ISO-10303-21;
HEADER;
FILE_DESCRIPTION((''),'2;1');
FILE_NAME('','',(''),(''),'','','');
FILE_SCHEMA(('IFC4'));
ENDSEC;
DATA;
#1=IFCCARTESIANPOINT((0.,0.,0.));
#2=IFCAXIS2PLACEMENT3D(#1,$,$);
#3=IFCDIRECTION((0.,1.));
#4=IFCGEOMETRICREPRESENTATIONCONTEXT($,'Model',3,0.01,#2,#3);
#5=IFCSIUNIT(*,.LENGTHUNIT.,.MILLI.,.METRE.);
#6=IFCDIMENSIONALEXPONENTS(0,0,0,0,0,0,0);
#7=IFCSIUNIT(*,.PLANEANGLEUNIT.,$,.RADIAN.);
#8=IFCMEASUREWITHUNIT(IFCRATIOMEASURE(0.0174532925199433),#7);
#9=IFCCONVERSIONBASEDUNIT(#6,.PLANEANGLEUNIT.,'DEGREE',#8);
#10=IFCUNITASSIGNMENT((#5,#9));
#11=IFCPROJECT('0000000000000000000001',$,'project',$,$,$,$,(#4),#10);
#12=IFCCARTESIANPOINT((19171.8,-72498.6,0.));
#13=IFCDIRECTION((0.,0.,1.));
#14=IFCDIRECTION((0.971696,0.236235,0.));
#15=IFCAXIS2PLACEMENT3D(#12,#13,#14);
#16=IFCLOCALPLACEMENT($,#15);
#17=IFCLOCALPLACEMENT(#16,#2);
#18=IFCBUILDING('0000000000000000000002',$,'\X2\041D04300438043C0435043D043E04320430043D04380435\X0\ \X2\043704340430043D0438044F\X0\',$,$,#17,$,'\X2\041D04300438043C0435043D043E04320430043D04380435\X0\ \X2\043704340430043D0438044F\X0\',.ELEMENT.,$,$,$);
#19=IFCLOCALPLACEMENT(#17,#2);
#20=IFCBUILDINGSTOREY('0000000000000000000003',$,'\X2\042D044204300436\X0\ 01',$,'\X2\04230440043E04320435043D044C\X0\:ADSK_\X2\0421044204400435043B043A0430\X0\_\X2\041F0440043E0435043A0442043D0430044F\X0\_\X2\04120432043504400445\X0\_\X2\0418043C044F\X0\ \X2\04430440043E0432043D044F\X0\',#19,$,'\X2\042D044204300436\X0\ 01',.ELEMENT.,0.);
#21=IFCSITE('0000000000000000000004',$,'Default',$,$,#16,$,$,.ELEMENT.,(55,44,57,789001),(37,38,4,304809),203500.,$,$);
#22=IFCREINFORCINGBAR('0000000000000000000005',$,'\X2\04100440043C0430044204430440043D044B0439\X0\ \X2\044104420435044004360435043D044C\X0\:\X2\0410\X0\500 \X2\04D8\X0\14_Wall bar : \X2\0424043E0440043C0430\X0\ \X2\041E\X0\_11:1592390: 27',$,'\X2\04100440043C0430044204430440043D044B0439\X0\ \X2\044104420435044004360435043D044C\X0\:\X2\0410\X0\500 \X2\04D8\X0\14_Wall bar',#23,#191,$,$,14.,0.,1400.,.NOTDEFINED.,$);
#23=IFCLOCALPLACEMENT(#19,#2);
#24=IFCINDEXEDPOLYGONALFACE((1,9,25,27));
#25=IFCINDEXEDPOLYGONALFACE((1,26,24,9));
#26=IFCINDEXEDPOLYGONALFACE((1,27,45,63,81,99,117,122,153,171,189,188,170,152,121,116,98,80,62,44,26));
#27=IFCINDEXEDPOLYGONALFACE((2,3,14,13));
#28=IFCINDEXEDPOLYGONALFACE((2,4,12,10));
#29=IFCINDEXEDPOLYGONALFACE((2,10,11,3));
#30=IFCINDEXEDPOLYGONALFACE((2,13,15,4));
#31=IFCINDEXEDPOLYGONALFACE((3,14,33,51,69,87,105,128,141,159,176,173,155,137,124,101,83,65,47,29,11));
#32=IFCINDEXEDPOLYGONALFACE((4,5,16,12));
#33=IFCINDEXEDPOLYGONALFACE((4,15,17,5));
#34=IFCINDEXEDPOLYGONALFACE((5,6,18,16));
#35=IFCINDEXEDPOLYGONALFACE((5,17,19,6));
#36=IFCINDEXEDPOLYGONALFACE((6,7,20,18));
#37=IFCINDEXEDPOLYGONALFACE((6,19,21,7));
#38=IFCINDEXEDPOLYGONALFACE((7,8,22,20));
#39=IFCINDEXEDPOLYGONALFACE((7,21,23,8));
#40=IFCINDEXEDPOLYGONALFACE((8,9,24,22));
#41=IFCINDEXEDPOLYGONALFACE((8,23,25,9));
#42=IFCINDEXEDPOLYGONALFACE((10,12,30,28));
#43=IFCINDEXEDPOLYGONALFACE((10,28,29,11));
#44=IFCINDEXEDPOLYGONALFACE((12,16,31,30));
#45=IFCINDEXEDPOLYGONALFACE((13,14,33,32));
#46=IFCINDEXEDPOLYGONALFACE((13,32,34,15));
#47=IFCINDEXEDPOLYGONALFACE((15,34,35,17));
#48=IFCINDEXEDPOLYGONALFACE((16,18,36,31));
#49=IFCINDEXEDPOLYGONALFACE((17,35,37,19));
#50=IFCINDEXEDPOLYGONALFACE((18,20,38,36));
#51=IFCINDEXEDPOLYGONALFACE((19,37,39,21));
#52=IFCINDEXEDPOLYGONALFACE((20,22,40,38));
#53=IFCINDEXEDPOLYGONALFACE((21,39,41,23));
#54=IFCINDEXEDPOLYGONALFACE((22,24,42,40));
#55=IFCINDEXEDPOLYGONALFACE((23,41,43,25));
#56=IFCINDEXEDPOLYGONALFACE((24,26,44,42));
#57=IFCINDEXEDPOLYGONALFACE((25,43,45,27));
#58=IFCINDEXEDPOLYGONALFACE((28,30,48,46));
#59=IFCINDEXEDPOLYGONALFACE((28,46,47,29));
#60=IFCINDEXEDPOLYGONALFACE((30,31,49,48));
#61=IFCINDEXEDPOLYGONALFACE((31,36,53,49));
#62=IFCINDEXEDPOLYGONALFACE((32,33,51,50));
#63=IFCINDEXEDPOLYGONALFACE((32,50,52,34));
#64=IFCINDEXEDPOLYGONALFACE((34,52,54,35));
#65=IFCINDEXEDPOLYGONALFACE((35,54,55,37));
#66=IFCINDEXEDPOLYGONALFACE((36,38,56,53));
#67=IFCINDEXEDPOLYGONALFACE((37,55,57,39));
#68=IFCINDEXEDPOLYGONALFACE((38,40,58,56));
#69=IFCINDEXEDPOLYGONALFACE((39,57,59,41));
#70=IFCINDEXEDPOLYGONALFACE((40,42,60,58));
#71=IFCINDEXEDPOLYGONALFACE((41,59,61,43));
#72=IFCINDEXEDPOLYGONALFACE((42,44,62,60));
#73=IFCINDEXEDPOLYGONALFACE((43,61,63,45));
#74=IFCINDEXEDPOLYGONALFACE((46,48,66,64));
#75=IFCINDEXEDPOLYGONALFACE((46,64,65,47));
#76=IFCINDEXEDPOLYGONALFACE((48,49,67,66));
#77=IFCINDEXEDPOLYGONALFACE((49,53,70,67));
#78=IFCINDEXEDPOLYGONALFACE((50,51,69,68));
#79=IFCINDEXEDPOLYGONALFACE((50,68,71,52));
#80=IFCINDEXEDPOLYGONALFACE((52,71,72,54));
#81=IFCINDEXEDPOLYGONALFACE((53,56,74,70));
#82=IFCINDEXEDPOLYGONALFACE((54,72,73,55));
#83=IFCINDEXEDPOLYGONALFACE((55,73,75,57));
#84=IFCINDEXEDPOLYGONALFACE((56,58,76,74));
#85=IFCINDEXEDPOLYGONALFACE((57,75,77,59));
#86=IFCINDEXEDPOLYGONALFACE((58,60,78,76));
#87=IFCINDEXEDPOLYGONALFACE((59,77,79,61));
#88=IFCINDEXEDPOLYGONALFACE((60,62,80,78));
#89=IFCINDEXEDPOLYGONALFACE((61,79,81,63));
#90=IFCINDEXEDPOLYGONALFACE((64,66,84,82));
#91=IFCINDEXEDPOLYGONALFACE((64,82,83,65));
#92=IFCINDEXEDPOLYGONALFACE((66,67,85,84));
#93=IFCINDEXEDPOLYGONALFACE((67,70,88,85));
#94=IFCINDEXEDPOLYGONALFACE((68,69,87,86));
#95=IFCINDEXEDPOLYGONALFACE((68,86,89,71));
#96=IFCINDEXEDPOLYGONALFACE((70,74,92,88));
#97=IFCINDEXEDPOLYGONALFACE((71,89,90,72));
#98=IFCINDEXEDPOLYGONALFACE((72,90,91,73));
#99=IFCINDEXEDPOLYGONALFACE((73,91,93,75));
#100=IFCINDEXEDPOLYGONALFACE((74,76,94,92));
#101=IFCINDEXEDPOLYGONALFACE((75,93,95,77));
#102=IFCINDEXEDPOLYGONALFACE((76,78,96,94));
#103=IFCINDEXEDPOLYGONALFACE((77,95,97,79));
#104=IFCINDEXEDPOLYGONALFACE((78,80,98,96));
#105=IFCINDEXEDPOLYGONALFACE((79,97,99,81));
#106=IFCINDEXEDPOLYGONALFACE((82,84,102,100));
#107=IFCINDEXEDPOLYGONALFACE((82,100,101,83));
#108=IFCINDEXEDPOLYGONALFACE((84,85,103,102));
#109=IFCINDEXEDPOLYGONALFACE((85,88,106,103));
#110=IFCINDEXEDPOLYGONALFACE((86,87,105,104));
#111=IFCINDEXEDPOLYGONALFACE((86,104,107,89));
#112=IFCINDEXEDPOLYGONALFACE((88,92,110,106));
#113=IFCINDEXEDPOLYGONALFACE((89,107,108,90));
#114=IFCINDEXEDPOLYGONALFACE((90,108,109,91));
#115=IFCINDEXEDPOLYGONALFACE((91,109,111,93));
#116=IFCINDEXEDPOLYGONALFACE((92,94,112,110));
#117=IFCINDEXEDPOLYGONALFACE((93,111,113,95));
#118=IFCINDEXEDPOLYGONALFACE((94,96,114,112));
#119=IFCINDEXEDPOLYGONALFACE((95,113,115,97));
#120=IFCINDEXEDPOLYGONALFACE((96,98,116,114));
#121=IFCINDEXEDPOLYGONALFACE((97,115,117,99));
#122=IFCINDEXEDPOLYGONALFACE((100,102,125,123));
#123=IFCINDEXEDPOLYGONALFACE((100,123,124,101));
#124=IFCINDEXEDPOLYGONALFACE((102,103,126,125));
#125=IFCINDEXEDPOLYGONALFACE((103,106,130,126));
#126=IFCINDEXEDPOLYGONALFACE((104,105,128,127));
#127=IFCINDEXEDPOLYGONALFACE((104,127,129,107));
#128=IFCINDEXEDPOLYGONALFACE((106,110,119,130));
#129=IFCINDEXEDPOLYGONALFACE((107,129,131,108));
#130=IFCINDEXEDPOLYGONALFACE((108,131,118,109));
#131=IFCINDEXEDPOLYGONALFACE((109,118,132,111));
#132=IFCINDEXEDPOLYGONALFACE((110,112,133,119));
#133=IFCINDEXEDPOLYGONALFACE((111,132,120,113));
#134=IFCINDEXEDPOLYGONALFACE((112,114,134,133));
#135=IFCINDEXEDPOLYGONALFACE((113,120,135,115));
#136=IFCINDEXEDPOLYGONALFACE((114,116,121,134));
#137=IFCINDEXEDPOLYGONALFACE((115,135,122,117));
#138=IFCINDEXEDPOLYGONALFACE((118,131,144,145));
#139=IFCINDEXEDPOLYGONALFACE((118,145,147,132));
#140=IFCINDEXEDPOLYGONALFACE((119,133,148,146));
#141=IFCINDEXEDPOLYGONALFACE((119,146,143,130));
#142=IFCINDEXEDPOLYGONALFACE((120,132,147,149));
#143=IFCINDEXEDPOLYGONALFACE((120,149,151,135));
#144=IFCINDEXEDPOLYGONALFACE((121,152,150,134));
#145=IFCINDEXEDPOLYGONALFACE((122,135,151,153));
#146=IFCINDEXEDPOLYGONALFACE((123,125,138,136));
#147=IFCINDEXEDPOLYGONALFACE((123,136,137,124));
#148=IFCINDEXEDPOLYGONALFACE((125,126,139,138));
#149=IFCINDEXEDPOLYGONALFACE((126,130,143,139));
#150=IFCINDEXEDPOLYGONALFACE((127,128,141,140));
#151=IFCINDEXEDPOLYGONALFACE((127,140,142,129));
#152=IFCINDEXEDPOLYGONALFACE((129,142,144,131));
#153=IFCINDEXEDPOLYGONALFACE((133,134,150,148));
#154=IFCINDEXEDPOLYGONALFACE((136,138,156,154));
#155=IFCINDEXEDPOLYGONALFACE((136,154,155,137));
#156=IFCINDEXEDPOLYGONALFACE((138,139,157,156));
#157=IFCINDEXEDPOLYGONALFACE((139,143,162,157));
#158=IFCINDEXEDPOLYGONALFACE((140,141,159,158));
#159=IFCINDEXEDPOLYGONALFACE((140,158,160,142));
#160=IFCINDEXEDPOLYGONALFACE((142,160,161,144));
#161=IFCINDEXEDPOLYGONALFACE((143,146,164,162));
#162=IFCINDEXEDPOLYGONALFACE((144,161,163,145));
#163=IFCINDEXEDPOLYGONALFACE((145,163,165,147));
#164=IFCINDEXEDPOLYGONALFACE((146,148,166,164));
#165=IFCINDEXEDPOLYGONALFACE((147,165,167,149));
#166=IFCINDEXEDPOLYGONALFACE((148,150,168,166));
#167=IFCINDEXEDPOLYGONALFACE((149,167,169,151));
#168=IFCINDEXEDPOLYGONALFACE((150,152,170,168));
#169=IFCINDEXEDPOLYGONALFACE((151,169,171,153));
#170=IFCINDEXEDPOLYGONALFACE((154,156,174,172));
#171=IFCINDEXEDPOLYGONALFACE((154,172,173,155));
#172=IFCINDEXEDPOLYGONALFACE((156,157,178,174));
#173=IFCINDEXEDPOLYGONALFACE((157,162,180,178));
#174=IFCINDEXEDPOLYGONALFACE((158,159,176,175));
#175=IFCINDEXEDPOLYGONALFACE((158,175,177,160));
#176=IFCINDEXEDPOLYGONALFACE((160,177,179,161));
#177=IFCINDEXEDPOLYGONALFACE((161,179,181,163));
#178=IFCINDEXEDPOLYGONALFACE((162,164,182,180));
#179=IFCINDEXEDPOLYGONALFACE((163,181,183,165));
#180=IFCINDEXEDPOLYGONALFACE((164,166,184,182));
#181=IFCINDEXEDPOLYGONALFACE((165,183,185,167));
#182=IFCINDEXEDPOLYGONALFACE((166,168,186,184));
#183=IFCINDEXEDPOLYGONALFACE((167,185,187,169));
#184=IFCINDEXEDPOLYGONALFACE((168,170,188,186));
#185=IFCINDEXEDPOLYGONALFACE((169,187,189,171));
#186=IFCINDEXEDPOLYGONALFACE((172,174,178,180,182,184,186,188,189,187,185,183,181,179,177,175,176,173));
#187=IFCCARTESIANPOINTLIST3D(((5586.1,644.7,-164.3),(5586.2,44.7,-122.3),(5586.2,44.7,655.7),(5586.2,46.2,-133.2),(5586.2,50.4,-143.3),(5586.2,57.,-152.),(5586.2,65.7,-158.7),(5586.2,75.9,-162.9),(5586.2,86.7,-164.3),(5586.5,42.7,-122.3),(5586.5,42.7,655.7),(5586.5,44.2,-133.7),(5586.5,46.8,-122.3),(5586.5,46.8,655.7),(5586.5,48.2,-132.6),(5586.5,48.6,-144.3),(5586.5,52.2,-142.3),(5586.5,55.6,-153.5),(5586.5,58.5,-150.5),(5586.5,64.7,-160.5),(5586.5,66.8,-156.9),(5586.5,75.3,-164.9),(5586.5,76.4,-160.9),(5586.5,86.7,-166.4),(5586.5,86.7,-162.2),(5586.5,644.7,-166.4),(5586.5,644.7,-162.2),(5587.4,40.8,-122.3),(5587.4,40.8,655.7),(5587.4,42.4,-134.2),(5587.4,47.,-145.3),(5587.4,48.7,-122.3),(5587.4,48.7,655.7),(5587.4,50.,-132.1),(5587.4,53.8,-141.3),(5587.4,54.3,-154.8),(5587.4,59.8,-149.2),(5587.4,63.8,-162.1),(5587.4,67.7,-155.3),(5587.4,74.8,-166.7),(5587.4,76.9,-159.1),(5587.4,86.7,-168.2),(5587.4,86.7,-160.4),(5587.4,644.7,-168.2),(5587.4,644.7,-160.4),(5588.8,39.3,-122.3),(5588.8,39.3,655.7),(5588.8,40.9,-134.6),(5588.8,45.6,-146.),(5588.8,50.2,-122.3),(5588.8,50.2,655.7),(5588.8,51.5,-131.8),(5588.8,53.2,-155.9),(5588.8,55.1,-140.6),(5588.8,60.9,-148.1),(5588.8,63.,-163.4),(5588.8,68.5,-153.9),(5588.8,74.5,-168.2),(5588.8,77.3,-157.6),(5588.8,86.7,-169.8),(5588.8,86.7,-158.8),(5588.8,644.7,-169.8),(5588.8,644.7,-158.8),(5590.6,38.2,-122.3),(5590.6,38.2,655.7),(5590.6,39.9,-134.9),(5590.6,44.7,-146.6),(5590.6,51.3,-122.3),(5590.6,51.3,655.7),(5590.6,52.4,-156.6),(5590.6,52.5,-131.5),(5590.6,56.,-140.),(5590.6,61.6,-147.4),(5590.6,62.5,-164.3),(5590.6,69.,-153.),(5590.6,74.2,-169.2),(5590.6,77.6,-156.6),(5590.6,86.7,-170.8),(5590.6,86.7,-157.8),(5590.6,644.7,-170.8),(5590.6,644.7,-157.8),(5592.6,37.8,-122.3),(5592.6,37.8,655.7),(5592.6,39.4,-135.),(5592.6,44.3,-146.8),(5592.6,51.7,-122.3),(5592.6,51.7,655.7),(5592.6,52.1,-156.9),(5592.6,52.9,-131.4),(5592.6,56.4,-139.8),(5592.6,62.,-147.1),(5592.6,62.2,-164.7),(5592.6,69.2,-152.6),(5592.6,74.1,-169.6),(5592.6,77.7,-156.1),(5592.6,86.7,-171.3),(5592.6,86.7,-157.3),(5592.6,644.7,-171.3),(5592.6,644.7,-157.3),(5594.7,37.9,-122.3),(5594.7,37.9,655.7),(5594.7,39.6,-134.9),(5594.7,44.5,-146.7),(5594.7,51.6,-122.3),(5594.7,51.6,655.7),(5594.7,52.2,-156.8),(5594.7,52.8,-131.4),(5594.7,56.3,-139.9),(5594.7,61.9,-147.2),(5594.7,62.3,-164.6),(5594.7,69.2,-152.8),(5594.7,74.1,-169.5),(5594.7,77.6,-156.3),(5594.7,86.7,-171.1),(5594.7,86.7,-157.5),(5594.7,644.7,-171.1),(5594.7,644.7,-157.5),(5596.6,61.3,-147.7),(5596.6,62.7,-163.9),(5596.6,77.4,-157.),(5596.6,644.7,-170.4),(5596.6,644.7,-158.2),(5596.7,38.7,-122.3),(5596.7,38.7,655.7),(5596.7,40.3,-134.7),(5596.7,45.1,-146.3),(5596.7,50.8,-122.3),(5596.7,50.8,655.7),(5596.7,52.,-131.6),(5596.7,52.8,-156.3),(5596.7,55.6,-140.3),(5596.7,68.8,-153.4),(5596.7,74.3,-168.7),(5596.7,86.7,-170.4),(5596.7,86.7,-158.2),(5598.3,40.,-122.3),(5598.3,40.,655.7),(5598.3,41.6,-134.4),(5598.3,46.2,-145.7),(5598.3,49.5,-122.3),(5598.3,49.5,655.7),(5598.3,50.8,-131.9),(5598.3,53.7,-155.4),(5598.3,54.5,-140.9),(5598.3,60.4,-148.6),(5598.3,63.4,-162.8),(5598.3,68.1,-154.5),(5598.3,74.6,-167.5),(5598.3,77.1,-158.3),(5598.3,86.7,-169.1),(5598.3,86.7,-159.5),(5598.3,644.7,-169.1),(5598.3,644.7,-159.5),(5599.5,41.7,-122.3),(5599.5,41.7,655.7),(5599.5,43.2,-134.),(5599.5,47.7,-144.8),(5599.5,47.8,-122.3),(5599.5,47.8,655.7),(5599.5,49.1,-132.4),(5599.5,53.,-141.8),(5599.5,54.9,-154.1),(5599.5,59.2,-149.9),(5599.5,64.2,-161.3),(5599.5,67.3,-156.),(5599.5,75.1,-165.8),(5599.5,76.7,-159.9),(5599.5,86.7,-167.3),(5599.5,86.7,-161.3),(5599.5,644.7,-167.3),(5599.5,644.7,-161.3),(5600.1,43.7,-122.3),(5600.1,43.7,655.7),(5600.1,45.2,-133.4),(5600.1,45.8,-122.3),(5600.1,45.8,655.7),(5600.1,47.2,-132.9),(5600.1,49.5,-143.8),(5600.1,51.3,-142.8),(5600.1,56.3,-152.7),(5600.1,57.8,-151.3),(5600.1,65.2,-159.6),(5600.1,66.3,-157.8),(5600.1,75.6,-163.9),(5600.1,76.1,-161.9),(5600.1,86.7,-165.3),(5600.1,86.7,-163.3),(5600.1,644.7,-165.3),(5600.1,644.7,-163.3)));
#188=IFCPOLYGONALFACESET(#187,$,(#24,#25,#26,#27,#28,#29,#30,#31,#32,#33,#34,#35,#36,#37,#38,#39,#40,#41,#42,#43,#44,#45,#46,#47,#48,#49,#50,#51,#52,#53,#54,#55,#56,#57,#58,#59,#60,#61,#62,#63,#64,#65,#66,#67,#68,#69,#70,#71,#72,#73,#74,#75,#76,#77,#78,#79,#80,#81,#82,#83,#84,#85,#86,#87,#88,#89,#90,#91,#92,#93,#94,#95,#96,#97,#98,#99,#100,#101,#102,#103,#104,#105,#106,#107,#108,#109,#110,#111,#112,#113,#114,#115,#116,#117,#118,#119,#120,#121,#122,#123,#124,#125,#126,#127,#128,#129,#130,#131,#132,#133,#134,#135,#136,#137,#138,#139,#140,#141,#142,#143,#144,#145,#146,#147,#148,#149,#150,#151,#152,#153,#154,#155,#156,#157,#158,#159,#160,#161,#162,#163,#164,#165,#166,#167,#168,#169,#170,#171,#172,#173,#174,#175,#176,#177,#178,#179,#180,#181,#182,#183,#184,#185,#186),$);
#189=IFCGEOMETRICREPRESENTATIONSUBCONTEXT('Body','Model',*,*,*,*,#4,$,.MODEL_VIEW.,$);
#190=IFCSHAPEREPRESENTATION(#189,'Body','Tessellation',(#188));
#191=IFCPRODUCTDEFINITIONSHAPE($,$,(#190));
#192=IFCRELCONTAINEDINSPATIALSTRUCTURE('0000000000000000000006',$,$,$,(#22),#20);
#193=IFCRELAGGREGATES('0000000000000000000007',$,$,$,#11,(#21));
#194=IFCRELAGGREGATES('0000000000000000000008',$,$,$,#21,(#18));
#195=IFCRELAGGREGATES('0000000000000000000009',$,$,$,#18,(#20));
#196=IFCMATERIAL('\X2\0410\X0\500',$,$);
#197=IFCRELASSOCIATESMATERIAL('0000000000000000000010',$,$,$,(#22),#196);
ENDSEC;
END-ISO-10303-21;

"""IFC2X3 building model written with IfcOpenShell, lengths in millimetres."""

from ifc_helpers import new_model, entity, si_unit, converted_unit, direction, frame, origin, place, context, subcontext, project, spatial, material, element, save


model = new_model("IFC2X3")

# Units and contexts
model_context = context("Model", 3, precision=0.01, world=origin(), true_north=direction((0.0, 1.0)))
body_context = subcontext(model_context, "Body", "Model", "MODEL_VIEW")
ifc_project = project(units=[si_unit("LENGTHUNIT", "METRE", prefix="MILLI"), converted_unit("PLANEANGLEUNIT", "DEGREE", entity("IfcRatioMeasure", 0.0174532925199433), si_unit("PLANEANGLEUNIT", "RADIAN"), dimensions=[0, 0, 0, 0, 0, 0, 0])], contexts=[model_context])

# Site, building, storey
site_placement = place(None, frame((19171.8, -72498.6, 0.0), z_axis=(0.0, 0.0, 1.0), x_axis=(0.971696, 0.236235, 0.0)))
site = spatial("IfcSite", under=ifc_project, at=site_placement, Name="Default", CompositionType="ELEMENT", RefLatitude=(55, 44, 57, 789001), RefLongitude=(37, 38, 4, 304809), RefElevation=203500.0)
building_placement = place(site_placement, origin())
building = spatial("IfcBuilding", under=site, at=building_placement, Name="Наименование здания", LongName="Наименование здания", CompositionType="ELEMENT")
storey_placement = place(building_placement, origin())
storey = spatial("IfcBuildingStorey", under=building, at=storey_placement, Name="Этаж 01", ObjectType="Уровень:ADSK_Стрелка_Проектная_Вверх_Имя уровня", LongName="Этаж 01", CompositionType="ELEMENT", Elevation=0.0)

# Reinforcing bar
ifc_material = material(Name="А500")
placement = place(storey_placement, origin())
element("IfcReinforcingBar", 1, at=placement, inside=storey, material=ifc_material, Name="Арматурный стержень:А500 Ә14_Wall bar : Форма О_11:1592390: 27", ObjectType="Арматурный стержень:А500 Ә14_Wall bar", BarLength=1400.0, BarRole="NOTDEFINED", CrossSectionArea=0.0, NominalDiameter=14.0, context=body_context, shape_type="AdvancedSweptSolid", body=[
    entity("IfcSweptDiskSolid", entity("IfcCompositeCurve", [entity("IfcCompositeCurveSegment", "CONTINUOUS", True, entity("IfcPolyline", [entity("IfcCartesianPoint", [5593.1, 44.7, 655.7]), entity("IfcCartesianPoint", [5593.1, 44.7, -122.3])])), entity("IfcCompositeCurveSegment", "CONTINUOUS", True, entity("IfcTrimmedCurve", entity("IfcCircle", entity("IfcAxis2Placement3D", entity("IfcCartesianPoint", [5593.1, 86.7, -122.3]), entity("IfcDirection", [1.0, 0.0, 0.0]), entity("IfcDirection", [0.0, 0.0, -1.0])), 42.0), [entity("IfcParameterValue", 270.0)], [entity("IfcParameterValue", 360.0)], True, "PARAMETER")), entity("IfcCompositeCurveSegment", "CONTINUOUS", True, entity("IfcPolyline", [entity("IfcCartesianPoint", [5593.1, 86.7, -164.3]), entity("IfcCartesianPoint", [5593.1, 644.7, -164.3])]))], False), 7.0, None, 0.0, 92.0),
])

save(model, "model.ifc")
